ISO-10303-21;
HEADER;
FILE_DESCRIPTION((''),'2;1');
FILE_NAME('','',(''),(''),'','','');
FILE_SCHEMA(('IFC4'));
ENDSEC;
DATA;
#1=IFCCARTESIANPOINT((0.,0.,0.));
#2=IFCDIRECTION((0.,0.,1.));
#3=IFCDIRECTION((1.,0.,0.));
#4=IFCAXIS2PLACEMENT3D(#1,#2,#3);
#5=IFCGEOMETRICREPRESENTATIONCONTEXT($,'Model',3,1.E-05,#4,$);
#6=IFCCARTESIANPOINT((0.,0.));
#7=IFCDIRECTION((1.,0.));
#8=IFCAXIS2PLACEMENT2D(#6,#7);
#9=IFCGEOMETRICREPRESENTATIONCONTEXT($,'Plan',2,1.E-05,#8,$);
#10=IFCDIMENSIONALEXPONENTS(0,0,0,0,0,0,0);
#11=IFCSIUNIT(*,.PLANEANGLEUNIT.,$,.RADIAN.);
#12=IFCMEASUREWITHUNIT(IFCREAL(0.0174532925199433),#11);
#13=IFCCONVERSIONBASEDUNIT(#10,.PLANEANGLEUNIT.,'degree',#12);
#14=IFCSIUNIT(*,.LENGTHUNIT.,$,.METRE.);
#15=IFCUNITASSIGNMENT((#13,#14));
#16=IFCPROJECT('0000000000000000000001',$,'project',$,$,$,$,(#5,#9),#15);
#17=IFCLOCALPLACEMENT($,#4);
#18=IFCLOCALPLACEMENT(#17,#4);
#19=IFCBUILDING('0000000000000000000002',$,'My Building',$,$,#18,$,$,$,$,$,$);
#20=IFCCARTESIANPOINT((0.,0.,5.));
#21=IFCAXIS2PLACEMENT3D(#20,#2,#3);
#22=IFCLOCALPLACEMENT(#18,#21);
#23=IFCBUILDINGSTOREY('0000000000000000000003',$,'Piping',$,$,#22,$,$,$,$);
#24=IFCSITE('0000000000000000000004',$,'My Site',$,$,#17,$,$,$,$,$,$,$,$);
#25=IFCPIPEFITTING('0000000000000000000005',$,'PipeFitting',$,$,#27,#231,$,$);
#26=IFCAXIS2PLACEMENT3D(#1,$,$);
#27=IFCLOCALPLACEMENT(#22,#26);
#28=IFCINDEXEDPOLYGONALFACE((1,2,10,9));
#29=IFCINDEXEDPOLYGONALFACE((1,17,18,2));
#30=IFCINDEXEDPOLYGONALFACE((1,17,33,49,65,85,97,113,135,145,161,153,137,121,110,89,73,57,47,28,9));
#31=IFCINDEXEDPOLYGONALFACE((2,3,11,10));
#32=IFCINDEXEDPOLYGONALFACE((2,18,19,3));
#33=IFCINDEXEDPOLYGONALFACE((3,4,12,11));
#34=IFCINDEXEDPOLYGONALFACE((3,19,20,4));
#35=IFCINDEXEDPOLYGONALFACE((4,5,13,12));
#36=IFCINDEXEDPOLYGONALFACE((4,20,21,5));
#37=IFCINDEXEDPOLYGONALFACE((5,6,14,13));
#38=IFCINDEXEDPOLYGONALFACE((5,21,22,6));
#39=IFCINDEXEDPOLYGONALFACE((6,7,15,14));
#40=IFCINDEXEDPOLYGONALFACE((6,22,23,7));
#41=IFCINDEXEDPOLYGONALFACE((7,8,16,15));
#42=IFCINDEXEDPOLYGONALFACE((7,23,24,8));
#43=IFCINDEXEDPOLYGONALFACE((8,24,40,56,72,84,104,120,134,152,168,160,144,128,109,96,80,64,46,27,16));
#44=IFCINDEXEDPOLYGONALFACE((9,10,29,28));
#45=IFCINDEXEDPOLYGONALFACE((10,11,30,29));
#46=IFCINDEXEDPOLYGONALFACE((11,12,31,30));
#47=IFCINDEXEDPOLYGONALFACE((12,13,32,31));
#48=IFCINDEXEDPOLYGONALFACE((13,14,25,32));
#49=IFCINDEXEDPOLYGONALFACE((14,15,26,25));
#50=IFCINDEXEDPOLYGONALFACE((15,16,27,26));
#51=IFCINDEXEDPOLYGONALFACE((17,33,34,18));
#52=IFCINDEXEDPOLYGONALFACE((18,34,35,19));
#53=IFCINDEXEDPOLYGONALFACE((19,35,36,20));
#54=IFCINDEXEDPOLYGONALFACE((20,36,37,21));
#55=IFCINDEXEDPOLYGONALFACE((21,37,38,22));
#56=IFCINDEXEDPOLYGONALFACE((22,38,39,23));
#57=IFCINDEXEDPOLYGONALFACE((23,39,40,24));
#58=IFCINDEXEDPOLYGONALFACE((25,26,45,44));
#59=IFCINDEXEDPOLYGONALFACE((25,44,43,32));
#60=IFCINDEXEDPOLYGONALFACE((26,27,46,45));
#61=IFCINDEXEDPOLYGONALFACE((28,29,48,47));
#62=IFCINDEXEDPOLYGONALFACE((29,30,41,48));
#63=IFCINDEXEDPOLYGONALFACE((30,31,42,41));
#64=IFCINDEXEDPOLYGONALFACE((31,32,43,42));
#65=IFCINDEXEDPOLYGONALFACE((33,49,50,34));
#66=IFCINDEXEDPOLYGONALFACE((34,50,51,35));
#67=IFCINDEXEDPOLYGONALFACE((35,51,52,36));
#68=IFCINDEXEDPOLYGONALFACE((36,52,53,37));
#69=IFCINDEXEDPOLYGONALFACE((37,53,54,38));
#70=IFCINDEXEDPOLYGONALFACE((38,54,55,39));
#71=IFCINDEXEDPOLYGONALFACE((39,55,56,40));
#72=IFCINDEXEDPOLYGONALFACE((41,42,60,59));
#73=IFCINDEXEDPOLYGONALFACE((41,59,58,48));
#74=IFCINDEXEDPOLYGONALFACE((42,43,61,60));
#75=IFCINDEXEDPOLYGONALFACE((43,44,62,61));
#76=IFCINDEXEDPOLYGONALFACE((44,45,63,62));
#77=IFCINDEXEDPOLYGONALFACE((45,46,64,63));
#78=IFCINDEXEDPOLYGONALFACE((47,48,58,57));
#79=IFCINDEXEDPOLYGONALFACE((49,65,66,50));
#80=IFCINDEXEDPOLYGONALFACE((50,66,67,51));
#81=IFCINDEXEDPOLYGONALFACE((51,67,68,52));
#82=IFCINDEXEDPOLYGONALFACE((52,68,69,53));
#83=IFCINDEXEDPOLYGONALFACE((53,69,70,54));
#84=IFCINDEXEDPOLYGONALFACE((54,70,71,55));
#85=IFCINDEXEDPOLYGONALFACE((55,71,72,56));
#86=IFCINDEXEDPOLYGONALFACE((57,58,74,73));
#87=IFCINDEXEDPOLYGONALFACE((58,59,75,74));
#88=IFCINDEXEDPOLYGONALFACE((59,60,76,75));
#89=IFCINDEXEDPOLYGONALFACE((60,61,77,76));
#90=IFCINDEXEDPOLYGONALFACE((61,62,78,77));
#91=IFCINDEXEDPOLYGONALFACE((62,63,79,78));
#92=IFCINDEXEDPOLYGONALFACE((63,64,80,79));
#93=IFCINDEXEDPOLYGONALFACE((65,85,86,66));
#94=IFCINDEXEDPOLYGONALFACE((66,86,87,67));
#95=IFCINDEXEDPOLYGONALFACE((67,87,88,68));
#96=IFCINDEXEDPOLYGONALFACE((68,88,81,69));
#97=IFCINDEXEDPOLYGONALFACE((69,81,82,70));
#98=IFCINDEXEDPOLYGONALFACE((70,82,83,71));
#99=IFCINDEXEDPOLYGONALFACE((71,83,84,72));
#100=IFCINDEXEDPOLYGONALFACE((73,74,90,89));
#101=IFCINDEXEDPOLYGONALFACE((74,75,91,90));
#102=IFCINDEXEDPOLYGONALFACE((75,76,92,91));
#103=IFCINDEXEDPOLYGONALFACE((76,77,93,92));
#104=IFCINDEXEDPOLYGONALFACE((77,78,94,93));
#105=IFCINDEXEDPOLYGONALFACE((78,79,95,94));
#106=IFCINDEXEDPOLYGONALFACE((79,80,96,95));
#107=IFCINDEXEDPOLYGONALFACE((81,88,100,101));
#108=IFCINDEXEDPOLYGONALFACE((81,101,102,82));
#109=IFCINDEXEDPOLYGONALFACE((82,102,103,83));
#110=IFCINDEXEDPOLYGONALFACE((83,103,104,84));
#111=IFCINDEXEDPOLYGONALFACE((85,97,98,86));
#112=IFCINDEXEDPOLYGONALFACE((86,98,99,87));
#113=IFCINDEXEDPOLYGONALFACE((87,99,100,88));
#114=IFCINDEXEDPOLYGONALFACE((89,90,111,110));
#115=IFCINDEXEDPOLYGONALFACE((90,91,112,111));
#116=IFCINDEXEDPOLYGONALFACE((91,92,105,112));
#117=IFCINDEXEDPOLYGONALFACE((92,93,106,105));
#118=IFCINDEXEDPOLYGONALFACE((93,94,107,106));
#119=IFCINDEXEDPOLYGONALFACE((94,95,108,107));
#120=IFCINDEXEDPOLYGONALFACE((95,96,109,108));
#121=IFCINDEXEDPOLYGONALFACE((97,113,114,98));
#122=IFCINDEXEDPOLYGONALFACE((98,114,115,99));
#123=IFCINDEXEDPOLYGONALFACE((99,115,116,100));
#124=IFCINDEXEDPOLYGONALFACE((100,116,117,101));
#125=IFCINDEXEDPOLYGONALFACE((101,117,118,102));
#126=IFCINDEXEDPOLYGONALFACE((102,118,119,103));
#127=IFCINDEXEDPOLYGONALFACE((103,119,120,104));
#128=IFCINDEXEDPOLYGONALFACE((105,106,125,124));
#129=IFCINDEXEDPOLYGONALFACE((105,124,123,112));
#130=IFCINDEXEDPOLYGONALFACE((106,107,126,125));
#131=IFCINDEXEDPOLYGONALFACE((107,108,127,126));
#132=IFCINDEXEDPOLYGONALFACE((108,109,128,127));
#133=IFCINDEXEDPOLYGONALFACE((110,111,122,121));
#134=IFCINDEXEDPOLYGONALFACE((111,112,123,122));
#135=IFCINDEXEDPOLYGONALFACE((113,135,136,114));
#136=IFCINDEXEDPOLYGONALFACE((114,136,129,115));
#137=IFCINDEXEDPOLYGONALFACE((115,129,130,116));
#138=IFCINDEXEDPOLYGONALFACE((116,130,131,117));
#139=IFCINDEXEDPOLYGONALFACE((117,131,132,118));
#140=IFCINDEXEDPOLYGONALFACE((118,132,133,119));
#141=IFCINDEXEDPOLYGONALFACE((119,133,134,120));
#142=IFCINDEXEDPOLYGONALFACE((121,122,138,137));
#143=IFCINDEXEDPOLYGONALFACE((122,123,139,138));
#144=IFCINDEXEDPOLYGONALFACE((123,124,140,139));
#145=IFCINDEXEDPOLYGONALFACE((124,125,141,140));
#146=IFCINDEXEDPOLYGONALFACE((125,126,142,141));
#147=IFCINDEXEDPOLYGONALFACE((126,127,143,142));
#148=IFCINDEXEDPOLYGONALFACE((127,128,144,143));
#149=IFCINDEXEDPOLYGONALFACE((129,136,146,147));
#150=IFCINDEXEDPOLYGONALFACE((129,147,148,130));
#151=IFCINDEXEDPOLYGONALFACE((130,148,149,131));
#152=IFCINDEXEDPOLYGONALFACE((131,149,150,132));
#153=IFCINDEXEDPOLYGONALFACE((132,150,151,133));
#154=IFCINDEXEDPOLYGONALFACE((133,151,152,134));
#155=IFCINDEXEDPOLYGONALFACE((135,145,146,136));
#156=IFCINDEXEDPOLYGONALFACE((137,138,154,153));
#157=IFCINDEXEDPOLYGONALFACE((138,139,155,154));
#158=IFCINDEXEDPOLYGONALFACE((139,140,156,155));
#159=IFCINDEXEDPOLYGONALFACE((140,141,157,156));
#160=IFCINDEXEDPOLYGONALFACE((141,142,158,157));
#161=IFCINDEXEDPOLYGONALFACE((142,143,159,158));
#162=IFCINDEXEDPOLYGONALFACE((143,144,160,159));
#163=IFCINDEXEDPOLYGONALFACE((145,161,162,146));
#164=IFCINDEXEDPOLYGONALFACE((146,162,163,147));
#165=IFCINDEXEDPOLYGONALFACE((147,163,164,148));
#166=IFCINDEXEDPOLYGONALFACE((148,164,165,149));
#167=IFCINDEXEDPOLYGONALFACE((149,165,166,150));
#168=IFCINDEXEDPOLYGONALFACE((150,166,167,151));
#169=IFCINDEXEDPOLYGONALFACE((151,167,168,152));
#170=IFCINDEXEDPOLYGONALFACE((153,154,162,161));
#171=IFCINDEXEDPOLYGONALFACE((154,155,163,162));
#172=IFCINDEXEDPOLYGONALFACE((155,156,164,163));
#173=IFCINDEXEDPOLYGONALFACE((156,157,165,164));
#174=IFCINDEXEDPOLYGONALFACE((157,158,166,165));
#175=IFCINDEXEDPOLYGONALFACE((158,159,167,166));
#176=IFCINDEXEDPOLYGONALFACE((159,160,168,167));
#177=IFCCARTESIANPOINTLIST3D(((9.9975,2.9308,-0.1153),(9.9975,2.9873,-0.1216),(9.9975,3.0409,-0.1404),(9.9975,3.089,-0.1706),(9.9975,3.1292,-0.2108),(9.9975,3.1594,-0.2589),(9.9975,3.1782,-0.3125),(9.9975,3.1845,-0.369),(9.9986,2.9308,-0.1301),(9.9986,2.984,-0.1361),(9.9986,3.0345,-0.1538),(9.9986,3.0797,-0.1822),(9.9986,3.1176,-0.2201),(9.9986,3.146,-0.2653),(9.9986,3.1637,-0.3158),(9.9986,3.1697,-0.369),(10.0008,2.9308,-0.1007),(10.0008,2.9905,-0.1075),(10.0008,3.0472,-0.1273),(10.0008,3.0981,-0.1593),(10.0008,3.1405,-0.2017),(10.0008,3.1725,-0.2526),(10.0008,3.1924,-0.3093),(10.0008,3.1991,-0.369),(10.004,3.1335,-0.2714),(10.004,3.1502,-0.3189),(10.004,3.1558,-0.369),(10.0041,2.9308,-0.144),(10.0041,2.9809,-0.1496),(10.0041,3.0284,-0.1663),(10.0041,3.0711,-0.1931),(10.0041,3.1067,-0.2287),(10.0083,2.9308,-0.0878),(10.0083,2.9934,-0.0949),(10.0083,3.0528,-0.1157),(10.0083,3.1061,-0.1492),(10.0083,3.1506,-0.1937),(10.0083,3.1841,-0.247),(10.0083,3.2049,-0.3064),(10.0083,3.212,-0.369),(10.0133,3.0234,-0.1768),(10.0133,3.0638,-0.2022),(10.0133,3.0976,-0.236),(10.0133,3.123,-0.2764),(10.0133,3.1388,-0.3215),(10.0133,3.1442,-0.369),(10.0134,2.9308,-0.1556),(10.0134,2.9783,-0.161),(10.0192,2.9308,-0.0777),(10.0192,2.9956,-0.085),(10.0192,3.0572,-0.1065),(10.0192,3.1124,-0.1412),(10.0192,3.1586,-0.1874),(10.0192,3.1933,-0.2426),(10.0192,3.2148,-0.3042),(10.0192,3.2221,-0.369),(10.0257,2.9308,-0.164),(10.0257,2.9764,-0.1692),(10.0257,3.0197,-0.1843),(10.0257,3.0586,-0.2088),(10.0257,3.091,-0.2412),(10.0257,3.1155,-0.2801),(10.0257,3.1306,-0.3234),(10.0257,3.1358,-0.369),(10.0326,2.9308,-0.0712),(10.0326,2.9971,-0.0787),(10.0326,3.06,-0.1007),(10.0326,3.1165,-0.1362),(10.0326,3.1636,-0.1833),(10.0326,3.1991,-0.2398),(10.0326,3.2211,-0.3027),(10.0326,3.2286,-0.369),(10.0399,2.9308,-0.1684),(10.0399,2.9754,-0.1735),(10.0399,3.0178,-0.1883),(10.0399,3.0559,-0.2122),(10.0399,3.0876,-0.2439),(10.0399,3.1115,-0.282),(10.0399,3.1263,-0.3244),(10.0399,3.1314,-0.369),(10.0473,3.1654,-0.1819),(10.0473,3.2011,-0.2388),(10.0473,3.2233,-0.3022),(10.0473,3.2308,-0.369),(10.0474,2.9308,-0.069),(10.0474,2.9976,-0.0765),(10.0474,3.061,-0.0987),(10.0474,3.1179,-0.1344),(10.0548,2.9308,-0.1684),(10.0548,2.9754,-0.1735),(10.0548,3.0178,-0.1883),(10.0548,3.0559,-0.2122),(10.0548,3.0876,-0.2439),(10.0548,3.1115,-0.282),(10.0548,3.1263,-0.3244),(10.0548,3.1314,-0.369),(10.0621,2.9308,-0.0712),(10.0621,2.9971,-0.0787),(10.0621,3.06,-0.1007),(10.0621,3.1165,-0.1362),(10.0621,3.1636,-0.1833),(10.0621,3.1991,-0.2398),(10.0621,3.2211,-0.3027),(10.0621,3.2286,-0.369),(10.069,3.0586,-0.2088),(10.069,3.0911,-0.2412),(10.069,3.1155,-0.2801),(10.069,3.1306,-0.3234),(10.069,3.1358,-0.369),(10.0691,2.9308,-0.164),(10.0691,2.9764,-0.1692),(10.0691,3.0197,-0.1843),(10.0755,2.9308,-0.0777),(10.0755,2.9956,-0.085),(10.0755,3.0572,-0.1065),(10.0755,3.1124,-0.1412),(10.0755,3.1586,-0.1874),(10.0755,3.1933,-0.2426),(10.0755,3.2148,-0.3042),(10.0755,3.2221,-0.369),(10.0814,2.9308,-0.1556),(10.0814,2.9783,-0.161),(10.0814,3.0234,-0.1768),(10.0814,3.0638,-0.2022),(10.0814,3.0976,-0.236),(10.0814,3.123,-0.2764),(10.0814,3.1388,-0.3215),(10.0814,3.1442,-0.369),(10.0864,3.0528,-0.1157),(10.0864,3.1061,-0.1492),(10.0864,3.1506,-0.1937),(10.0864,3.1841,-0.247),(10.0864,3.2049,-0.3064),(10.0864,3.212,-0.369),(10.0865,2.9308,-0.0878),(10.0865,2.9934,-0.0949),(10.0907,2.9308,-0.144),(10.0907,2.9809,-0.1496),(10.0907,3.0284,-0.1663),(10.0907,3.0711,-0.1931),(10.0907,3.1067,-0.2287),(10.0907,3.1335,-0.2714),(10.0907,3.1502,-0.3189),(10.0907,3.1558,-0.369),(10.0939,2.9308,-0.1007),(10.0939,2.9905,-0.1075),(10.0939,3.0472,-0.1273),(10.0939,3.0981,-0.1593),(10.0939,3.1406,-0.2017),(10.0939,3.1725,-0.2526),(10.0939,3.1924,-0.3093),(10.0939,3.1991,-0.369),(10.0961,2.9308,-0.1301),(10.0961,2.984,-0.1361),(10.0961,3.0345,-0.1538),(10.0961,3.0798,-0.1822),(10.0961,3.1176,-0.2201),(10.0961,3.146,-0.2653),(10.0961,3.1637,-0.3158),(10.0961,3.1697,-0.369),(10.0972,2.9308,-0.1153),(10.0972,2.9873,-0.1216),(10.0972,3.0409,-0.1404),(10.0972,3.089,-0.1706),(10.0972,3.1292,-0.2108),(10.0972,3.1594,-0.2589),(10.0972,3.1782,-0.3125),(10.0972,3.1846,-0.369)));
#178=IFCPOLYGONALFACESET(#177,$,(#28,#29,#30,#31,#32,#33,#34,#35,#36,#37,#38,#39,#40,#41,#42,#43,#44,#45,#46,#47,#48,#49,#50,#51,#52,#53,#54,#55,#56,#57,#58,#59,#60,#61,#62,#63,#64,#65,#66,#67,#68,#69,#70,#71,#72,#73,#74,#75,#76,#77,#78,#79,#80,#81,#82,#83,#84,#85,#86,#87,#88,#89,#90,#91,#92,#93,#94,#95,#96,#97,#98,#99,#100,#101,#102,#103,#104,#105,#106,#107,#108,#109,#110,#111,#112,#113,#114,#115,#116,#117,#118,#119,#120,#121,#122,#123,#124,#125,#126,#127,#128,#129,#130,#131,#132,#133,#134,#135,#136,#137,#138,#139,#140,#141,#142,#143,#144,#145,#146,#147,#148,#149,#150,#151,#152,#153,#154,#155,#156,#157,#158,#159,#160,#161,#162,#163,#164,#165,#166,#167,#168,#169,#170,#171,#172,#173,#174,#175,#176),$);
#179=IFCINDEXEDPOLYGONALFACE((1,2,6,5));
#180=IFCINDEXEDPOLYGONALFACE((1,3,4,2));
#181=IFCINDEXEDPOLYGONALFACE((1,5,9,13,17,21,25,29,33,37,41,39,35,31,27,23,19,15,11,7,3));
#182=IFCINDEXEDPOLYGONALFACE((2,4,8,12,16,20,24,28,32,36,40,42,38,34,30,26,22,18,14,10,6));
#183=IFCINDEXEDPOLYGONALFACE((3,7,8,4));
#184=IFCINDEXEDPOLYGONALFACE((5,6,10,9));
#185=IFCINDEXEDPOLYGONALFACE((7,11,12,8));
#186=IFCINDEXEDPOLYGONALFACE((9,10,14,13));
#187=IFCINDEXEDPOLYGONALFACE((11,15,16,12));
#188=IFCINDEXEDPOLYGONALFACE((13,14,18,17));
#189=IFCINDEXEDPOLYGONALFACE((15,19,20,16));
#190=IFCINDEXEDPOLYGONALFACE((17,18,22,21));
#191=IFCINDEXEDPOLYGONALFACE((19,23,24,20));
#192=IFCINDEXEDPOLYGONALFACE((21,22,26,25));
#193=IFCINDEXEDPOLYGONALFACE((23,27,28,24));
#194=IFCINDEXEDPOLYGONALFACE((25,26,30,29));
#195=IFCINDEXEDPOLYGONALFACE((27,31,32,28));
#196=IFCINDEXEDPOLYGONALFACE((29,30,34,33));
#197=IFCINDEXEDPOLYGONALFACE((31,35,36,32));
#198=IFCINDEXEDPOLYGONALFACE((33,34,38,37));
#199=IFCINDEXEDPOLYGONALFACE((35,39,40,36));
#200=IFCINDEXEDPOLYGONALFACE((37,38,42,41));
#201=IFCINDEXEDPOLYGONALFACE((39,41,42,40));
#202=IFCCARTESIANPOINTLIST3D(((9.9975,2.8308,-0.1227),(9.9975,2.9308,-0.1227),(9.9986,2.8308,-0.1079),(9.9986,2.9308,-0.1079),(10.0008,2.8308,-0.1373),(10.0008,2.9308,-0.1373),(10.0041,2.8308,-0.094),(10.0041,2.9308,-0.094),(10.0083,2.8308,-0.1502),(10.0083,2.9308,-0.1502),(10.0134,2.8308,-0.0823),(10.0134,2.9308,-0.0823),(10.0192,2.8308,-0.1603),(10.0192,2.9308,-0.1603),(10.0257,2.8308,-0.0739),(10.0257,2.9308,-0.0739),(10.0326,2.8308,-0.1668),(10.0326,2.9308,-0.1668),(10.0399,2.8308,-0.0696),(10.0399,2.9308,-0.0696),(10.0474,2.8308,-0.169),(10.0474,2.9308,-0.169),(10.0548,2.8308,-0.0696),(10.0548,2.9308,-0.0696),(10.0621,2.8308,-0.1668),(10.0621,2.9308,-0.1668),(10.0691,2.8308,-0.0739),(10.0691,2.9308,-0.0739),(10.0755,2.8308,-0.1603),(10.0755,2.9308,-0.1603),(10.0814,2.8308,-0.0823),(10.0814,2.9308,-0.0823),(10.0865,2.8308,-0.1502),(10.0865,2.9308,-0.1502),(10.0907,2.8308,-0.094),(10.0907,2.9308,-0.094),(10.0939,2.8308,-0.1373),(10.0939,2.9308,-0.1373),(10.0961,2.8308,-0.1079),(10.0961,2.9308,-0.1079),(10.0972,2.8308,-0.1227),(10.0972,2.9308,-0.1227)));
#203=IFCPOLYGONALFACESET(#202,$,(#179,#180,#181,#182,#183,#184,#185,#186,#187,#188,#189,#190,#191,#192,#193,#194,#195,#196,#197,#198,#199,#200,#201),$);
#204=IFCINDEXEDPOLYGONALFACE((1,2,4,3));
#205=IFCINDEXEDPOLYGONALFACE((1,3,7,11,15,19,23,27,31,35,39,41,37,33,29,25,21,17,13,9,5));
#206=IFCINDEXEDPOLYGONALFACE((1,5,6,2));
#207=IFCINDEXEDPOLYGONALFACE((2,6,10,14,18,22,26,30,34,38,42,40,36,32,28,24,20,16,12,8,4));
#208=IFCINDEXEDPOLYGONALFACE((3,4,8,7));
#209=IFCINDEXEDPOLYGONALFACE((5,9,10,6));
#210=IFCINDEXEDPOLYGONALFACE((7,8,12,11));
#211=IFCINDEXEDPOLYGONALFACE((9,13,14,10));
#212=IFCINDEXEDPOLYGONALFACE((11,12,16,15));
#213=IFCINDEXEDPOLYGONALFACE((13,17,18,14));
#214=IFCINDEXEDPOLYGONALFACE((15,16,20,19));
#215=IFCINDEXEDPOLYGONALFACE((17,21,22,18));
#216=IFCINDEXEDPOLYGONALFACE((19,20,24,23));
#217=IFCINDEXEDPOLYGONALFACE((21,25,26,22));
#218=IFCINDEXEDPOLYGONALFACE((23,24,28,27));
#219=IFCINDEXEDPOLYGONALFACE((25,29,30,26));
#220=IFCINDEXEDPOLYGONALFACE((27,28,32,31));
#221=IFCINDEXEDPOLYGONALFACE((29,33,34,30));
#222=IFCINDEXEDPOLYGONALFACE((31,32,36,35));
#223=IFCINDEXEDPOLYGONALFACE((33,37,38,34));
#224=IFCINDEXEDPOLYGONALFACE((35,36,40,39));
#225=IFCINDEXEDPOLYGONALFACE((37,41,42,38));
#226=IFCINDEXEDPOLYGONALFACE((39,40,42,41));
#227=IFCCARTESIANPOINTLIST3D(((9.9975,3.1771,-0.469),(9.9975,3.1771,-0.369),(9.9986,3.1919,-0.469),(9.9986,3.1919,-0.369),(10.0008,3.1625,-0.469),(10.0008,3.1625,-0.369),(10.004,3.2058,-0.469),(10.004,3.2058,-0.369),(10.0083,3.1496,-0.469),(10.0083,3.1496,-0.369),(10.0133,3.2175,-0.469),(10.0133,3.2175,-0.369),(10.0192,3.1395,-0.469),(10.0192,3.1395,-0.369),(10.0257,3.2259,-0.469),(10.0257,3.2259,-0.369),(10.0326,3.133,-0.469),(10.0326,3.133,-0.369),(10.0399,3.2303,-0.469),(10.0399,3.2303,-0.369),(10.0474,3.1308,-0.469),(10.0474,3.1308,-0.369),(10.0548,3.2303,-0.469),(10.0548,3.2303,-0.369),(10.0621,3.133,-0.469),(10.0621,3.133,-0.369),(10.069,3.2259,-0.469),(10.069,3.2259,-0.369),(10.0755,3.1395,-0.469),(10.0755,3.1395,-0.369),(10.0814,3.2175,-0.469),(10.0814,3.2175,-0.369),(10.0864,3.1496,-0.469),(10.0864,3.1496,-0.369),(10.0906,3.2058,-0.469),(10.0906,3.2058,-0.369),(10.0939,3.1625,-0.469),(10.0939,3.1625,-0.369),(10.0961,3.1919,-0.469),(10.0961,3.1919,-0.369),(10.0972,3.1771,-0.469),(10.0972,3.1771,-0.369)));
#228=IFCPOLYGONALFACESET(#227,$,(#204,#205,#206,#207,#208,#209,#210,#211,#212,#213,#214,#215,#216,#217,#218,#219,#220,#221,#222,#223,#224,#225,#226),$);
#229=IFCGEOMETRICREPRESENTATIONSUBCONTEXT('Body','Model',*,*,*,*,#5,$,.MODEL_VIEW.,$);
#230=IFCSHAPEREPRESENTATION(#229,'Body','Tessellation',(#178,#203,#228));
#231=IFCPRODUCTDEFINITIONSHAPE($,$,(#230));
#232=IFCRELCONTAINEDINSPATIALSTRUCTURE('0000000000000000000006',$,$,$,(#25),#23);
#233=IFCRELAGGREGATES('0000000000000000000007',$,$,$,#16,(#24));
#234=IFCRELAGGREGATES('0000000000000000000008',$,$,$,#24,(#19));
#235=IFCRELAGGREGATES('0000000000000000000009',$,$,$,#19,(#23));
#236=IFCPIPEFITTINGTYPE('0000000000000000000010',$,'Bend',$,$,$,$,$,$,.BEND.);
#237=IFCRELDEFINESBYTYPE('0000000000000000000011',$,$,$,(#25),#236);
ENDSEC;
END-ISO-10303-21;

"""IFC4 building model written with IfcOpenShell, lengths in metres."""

from ifc_helpers import new_model, entity, si_unit, converted_unit, frame, origin_with_axes, origin_2d_with_axis, place, context, subcontext, project, spatial, circle, extrude, source, transform, mapped, type_object, type_shapes, element, save


model = new_model("IFC4")

# Units and contexts
model_context = context("Model", 3, precision=1e-05, world=origin_with_axes())
plan_context = context("Plan", 2, precision=1e-05, world=origin_2d_with_axis())
body_context = subcontext(model_context, "Body", "Model", "MODEL_VIEW")
ifc_project = project(units=[converted_unit("PLANEANGLEUNIT", "degree", entity("IfcReal", 0.0174532925199433), si_unit("PLANEANGLEUNIT", "RADIAN"), dimensions=[0, 0, 0, 0, 0, 0, 0]), si_unit("LENGTHUNIT", "METRE")], contexts=[model_context, plan_context])

# Site, building, storey
site_placement = place(None, origin_with_axes())
site = spatial("IfcSite", under=ifc_project, at=site_placement, Name="My Site")
building_placement = place(site_placement, origin_with_axes())
building = spatial("IfcBuilding", under=site, at=building_placement, Name="My Building")
storey_placement = place(building_placement, frame((0.0, 0.0, 5.0), z_axis=(0.0, 0.0, 1.0), x_axis=(1.0, 0.0, 0.0)))
storey = spatial("IfcBuildingStorey", under=building, at=storey_placement, Name="Piping")

# Pipe fitting
pipe_fitting_type_1 = type_object("IfcPipeFittingType", Name="Bend", PredefinedType="BEND")
shared_shape = source(origin_with_axes(), body_context, "Body", "SolidModel", [
    entity("IfcSweptDiskSolid", entity("IfcIndexedPolyCurve", entity("IfcCartesianPointList3D", [[0.0, 0.0, -0.1], [0.0732, 0.0, -0.2768], [0.25, 0.0, -0.35]]), [entity("IfcArcIndex", [1, 2, 3])]), 0.05),
    extrude(circle(Radius=0.05), origin_with_axes(), (0.0, 0.0, -1.0), 0.1),
    extrude(circle(Radius=0.05), frame((0.25, 0.0, -0.35), z_axis=(1.0, 0.0, 0.0), x_axis=(0.0, 0.0, 1.0)), (0.0, 0.0, 1.0), 0.1),
])
type_shapes(pipe_fitting_type_1, [shared_shape])
for number, where, z_axis, x_axis, name in (
    (1, (10.0474, 2.8308, -0.119), (0.00006, -1.0, 0.0), (0.0, 0.0, -1.0), "PipeFitting"),
):
    element("IfcPipeFitting", number, at=place(storey_placement, frame(where, z_axis=z_axis, x_axis=x_axis)), inside=storey, type_object=pipe_fitting_type_1, Name=name, context=body_context, shape_type="MappedRepresentation", body=[
        mapped(shared_shape, transform((0.0, 0.0, 0.0), x_axis=(1.0, 0.0, 0.0), y_axis=(0.0, 1.0, 0.0), z_axis=(0.0, 0.0, 1.0), scale=1.0)),
    ])

save(model, "model.ifc")
